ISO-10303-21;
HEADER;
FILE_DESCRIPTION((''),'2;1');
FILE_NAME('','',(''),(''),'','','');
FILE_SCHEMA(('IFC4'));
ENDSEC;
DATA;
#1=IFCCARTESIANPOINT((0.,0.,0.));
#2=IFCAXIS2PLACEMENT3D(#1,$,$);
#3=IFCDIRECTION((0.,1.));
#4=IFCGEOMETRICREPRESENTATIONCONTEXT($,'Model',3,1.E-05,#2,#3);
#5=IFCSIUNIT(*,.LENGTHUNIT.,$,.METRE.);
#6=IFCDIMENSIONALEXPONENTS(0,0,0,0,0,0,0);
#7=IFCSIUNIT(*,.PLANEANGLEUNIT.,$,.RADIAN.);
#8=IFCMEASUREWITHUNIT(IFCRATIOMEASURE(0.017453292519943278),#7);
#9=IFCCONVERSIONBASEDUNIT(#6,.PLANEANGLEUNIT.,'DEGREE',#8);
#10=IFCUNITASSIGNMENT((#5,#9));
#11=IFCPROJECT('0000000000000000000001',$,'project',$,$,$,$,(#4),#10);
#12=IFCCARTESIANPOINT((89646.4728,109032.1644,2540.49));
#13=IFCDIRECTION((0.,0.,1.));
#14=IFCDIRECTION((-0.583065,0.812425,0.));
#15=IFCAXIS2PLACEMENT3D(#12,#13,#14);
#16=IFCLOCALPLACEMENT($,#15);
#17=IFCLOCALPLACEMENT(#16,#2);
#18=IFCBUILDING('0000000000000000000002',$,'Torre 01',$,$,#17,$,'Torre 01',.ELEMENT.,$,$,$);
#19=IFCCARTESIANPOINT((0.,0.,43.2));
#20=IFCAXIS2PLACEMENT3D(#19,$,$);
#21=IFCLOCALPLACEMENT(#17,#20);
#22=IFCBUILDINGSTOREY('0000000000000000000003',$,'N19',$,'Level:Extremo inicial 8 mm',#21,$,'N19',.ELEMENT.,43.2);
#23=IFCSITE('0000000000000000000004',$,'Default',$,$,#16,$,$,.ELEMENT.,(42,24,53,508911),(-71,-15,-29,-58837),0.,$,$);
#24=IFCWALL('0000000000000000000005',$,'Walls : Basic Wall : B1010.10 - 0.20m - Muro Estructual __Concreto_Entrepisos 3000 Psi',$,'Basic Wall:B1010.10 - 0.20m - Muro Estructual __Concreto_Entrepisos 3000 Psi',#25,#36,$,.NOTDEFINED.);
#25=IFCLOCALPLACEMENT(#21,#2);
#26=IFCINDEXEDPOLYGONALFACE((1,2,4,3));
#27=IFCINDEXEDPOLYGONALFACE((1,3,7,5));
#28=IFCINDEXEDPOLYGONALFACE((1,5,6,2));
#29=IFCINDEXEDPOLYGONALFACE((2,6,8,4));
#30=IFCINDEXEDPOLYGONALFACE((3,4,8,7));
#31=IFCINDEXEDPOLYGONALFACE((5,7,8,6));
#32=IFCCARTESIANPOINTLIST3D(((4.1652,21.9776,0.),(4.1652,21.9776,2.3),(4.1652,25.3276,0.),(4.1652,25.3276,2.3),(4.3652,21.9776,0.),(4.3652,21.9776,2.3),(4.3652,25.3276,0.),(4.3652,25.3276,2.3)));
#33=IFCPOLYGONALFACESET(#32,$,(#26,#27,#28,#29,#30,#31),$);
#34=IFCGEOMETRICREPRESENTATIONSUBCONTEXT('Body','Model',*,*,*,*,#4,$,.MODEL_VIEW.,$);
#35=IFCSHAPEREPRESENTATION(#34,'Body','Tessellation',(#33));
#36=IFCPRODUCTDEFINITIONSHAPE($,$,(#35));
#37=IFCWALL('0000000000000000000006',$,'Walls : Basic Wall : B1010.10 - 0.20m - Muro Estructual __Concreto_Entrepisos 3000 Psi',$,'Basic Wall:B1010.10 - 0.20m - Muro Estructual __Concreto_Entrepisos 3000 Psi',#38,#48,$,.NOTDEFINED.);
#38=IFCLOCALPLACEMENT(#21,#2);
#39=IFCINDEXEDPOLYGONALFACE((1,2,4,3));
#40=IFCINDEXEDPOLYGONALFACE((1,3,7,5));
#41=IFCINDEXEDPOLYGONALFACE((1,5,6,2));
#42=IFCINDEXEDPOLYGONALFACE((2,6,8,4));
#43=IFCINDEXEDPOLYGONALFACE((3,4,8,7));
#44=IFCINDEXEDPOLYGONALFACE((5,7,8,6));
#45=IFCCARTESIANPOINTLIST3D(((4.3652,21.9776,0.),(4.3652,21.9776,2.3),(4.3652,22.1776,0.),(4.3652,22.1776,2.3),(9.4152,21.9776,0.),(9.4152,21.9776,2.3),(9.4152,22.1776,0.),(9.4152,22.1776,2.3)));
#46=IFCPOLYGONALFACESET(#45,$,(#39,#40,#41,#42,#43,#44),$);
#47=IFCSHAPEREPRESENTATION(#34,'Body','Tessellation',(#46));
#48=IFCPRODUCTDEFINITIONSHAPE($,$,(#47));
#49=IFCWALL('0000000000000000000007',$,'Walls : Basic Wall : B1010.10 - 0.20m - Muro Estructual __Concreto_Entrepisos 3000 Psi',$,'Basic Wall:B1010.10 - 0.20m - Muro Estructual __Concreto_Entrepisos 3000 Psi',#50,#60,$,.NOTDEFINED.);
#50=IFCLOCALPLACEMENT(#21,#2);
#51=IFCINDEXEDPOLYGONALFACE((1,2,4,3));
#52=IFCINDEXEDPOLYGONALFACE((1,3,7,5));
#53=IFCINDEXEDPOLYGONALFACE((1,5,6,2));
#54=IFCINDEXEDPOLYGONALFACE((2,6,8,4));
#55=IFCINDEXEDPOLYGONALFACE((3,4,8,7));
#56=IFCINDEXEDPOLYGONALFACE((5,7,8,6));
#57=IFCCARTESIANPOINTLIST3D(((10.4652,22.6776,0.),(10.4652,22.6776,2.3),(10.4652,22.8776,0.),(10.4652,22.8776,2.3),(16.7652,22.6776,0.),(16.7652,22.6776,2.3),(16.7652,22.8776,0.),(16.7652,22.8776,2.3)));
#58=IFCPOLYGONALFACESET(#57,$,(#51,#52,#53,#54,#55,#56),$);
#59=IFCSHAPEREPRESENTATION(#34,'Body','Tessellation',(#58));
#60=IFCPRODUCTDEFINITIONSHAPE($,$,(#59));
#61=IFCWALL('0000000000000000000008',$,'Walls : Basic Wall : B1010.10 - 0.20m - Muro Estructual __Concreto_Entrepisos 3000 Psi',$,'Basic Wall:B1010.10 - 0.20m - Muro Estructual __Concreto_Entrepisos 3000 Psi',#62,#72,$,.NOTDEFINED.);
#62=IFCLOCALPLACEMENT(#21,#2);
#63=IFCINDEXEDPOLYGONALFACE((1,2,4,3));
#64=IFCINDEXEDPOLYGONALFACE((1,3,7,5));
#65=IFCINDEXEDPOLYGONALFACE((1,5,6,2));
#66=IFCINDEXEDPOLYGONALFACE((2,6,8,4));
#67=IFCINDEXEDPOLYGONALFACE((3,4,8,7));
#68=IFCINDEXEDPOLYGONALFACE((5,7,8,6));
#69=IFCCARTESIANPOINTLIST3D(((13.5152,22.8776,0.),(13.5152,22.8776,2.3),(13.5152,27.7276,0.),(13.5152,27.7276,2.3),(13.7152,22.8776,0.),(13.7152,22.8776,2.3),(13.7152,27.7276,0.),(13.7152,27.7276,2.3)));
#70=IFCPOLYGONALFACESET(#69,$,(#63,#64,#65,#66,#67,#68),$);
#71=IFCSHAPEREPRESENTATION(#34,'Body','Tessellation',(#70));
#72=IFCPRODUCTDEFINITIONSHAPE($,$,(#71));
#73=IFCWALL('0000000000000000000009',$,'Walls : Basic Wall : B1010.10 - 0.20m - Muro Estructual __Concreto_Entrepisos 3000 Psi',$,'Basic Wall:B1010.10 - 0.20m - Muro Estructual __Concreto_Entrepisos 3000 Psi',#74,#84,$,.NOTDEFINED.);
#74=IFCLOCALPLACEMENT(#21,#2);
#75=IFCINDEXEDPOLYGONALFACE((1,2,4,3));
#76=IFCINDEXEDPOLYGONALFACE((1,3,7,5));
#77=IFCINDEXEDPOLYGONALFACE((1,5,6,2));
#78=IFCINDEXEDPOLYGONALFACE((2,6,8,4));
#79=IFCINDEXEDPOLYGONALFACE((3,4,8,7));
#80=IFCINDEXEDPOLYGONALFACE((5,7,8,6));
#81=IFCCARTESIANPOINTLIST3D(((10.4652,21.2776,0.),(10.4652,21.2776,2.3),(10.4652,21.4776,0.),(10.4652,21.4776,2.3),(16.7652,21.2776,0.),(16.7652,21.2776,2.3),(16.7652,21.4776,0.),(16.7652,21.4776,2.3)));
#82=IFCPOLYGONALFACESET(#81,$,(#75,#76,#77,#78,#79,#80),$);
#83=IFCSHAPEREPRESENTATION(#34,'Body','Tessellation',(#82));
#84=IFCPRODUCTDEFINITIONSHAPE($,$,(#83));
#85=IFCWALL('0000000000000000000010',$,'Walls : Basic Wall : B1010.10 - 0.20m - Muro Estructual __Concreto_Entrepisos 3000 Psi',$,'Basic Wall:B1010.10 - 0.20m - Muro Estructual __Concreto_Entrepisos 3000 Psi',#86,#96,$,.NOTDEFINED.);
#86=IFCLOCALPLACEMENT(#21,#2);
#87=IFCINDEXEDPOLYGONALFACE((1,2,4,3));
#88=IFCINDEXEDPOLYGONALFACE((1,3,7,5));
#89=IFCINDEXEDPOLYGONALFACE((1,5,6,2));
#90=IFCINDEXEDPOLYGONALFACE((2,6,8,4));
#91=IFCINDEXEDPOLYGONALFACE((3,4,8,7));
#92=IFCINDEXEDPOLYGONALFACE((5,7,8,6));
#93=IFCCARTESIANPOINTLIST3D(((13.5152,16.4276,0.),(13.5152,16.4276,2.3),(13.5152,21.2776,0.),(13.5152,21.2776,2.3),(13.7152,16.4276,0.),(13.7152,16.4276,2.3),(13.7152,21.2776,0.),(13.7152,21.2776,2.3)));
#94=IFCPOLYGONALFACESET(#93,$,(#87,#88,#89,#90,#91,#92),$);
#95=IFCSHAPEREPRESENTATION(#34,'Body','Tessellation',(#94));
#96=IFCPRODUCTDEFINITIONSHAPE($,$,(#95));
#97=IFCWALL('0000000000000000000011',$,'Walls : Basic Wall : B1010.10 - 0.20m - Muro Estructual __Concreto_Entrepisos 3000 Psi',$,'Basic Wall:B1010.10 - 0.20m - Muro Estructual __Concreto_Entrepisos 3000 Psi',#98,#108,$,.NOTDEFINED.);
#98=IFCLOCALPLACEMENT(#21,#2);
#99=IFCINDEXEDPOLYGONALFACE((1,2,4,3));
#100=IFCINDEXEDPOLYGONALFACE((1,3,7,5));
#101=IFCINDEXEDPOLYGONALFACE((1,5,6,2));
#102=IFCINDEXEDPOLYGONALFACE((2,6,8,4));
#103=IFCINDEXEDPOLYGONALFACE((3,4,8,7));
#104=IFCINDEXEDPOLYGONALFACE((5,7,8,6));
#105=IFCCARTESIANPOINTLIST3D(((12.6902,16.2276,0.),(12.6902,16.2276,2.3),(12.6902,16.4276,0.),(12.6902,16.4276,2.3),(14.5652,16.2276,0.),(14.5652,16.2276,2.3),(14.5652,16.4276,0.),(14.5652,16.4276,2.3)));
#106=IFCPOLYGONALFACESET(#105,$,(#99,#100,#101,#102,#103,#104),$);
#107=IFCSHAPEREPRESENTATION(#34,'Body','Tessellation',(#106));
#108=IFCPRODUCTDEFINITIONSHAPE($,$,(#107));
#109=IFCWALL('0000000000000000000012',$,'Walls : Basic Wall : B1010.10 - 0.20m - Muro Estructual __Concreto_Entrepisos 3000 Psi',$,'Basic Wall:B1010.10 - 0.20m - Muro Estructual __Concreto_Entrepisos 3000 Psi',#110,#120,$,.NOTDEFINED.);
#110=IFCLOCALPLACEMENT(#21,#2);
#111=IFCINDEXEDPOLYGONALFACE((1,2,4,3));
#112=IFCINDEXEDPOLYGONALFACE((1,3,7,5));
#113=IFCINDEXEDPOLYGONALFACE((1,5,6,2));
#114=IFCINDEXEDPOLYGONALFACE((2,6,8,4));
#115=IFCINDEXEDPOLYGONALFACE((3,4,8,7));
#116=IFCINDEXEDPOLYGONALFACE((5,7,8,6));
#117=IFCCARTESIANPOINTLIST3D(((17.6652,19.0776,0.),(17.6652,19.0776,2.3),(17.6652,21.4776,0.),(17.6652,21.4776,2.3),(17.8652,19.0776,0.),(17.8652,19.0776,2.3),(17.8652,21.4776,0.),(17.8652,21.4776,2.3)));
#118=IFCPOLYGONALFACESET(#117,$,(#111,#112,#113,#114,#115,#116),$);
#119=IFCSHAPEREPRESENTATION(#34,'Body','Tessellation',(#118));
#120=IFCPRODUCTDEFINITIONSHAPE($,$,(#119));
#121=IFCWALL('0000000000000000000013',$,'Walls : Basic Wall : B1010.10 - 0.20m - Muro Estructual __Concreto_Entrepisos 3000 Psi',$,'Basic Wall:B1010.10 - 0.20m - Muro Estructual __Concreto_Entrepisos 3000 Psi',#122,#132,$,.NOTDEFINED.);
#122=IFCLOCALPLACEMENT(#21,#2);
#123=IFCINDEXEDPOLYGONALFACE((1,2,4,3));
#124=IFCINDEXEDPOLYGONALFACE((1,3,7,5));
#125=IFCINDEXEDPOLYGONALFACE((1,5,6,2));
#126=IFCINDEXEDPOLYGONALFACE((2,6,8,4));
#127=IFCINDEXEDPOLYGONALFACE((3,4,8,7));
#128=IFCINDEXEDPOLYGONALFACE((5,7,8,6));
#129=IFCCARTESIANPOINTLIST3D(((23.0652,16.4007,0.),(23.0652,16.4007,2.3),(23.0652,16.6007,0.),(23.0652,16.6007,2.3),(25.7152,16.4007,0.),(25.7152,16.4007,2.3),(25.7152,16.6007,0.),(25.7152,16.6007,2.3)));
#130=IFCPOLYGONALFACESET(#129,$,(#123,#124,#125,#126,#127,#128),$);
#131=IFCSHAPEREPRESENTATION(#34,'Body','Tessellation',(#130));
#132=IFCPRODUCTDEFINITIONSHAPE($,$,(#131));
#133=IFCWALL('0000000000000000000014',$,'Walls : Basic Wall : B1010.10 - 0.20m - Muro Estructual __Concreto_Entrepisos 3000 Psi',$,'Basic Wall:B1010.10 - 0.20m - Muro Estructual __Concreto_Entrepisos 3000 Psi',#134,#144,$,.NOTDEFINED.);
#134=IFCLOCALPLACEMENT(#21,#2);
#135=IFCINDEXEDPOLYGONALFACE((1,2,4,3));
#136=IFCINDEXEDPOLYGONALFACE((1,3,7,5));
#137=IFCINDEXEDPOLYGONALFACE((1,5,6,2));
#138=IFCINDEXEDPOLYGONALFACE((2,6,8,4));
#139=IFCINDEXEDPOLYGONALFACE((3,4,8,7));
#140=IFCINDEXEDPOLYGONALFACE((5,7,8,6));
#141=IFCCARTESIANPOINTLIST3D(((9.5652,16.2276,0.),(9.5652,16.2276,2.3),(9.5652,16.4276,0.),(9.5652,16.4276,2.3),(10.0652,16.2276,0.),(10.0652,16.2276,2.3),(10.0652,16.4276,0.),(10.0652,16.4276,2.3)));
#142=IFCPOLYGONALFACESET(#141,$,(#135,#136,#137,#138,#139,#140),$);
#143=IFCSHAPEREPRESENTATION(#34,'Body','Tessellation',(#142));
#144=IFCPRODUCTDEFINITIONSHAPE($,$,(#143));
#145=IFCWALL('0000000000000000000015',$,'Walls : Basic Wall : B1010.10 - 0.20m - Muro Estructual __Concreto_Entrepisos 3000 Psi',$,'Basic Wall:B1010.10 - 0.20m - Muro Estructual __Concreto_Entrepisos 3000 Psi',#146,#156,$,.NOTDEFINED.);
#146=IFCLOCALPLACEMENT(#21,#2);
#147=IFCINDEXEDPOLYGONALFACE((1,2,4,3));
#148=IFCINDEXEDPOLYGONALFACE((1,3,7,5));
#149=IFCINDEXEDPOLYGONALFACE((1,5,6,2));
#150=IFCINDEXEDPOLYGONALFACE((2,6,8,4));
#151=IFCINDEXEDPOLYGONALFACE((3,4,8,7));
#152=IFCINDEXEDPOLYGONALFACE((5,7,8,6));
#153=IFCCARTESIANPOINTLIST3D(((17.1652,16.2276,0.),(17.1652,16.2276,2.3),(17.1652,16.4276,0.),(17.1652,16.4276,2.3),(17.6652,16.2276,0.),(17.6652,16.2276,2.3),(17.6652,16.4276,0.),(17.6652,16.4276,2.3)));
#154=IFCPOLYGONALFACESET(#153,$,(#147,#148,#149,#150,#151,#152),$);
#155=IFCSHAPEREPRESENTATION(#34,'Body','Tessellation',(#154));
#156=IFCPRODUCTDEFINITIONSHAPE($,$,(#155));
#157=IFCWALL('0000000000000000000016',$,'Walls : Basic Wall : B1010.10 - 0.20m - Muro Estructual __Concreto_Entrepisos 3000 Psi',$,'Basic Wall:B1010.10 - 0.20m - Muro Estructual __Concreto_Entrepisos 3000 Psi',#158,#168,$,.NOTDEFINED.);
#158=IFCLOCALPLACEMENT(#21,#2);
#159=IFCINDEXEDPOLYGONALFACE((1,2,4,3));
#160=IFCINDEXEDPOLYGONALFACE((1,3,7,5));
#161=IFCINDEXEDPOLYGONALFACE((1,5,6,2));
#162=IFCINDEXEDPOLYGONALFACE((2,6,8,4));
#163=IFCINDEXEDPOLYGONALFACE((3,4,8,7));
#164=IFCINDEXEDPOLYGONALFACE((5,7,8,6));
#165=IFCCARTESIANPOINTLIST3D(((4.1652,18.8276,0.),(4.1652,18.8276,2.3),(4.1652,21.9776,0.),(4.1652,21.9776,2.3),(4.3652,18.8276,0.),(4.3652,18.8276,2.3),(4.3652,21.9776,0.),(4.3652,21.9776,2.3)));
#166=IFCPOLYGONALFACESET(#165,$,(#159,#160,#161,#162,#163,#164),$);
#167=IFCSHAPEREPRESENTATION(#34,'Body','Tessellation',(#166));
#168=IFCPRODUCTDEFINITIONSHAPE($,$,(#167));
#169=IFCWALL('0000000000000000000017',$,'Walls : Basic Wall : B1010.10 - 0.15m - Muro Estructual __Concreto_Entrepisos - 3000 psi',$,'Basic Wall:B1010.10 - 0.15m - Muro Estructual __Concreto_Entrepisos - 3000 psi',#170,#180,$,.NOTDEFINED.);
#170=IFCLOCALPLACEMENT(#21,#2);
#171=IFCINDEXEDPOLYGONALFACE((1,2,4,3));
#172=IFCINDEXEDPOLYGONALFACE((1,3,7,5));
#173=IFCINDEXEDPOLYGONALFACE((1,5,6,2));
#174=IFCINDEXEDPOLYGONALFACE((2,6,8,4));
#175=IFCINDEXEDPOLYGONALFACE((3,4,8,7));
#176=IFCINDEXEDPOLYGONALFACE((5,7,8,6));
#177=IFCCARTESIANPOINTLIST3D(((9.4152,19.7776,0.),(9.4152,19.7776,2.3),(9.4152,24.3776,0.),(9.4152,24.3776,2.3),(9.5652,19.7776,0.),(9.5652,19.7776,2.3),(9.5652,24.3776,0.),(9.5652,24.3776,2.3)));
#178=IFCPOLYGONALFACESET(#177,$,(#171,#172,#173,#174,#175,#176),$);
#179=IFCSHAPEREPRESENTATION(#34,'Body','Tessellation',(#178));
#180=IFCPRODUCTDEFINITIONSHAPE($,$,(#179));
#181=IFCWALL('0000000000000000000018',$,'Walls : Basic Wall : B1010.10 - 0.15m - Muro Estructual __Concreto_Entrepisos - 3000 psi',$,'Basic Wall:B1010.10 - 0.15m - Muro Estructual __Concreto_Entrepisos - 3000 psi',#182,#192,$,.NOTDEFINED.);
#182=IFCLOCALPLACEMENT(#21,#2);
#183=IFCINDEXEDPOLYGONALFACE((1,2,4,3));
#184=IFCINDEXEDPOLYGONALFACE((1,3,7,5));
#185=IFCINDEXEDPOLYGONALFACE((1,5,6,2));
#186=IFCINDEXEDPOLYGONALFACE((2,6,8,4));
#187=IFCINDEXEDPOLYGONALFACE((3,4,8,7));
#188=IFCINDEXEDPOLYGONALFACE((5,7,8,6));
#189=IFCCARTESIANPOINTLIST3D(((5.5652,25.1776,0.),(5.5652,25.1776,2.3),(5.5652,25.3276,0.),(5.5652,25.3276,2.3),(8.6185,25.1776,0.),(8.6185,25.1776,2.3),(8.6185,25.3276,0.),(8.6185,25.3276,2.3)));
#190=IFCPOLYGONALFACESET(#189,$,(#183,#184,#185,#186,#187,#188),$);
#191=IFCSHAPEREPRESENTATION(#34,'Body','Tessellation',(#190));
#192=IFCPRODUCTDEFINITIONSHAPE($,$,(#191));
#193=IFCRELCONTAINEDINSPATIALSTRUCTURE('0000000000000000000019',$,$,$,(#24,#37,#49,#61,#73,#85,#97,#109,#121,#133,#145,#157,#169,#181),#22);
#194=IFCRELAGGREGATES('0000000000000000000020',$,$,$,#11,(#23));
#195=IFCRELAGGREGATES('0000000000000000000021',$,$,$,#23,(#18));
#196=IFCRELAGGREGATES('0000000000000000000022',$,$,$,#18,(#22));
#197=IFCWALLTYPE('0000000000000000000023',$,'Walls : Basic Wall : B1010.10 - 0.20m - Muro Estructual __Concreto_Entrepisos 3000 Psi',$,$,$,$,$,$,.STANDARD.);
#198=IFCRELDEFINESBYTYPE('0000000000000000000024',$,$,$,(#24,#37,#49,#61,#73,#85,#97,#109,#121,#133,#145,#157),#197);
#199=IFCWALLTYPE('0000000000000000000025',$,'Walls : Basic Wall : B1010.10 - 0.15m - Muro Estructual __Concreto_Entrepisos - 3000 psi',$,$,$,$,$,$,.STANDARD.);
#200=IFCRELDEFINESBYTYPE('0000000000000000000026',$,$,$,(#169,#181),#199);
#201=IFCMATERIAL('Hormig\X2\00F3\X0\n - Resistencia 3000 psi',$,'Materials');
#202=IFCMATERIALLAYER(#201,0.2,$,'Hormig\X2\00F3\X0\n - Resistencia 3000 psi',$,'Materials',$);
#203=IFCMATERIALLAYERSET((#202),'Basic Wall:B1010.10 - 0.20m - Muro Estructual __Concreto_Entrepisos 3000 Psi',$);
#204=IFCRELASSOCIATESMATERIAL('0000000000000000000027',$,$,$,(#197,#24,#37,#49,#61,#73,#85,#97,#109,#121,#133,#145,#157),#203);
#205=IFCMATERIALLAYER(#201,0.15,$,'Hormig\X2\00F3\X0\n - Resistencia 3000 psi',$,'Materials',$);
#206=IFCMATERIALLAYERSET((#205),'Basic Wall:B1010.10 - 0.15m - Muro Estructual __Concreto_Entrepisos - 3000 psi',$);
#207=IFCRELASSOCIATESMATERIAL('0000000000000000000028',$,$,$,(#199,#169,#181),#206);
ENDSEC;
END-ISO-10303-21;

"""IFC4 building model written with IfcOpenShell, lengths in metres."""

from ifc_helpers import new_model, entity, si_unit, converted_unit, direction, frame, frame_2d, origin, place, context, subcontext, project, spatial, rectangle, extrude, material, layer, layer_set, layer_usage, type_object, element, save


model = new_model("IFC4")

# Units and contexts
model_context = context("Model", 3, precision=1e-05, world=origin(), true_north=direction((0.0, 1.0)))
body_context = subcontext(model_context, "Body", "Model", "MODEL_VIEW")
ifc_project = project(units=[si_unit("LENGTHUNIT", "METRE"), converted_unit("PLANEANGLEUNIT", "DEGREE", entity("IfcRatioMeasure", 0.017453292519943278), si_unit("PLANEANGLEUNIT", "RADIAN"), dimensions=[0, 0, 0, 0, 0, 0, 0])], contexts=[model_context])

# Site, building, storey
site_placement = place(None, frame((89646.4728, 109032.1644, 2540.49), z_axis=(0.0, 0.0, 1.0), x_axis=(-0.583065, 0.812425, 0.0)))
site = spatial("IfcSite", under=ifc_project, at=site_placement, Name="Default", CompositionType="ELEMENT", RefLatitude=(42, 24, 53, 508911), RefLongitude=(-71, -15, -29, -58837), RefElevation=0.0)
building_placement = place(site_placement, origin())
building = spatial("IfcBuilding", under=site, at=building_placement, Name="Torre 01", LongName="Torre 01", CompositionType="ELEMENT")
storey_placement = place(building_placement, frame((0.0, 0.0, 43.2)))
storey = spatial("IfcBuildingStorey", under=building, at=storey_placement, Name="N19", ObjectType="Level:Extremo inicial 8 mm", LongName="N19", CompositionType="ELEMENT", Elevation=43.2)

# Walls
ifc_material = material(Name="Hormigón - Resistencia 3000 psi", Category="Materials")
ifc_layer_1 = layer(ifc_material, 0.2, Name="Hormigón - Resistencia 3000 psi", Category="Materials")
ifc_layer_set_1 = layer_set([ifc_layer_1], Name="Basic Wall:B1010.10 - 0.20m - Muro Estructual __Concreto_Entrepisos 3000 Psi")
ifc_layer_usage_1 = layer_usage(ifc_layer_set_1, "AXIS2", "NEGATIVE", 0.1)
wall_type_1 = type_object("IfcWallType", Name="Walls : Basic Wall : B1010.10 - 0.20m - Muro Estructual __Concreto_Entrepisos 3000 Psi", PredefinedType="STANDARD", material=ifc_layer_set_1)
wall_1_placement = place(storey_placement, frame((4.2652, 25.3276, 0.0), z_axis=(0.0, 0.0, 1.0), x_axis=(0.0, -1.0, 0.0)))
element("IfcWall", 1, at=wall_1_placement, inside=storey, type_object=wall_type_1, material=ifc_layer_usage_1, Name="Walls : Basic Wall : B1010.10 - 0.20m - Muro Estructual __Concreto_Entrepisos 3000 Psi", ObjectType="Basic Wall:B1010.10 - 0.20m - Muro Estructual __Concreto_Entrepisos 3000 Psi", PredefinedType="NOTDEFINED", context=body_context, shape_type="SweptSolid", body=[
    extrude(rectangle(XDim=3.35, YDim=0.2, at=frame_2d((1.675, 0.0), x_axis=(-1.0, 0.0))), origin(), (0.0, 0.0, 1.0), 2.3),
])
ifc_layer_usage_2 = layer_usage(ifc_layer_set_1, "AXIS2", "NEGATIVE", 0.1)
wall_2_placement = place(storey_placement, frame((4.3652, 22.0776, 0.0)))
element("IfcWall", 2, at=wall_2_placement, inside=storey, type_object=wall_type_1, material=ifc_layer_usage_2, Name="Walls : Basic Wall : B1010.10 - 0.20m - Muro Estructual __Concreto_Entrepisos 3000 Psi", ObjectType="Basic Wall:B1010.10 - 0.20m - Muro Estructual __Concreto_Entrepisos 3000 Psi", PredefinedType="NOTDEFINED", context=body_context, shape_type="SweptSolid", body=[
    extrude(rectangle(XDim=5.05, YDim=0.2, at=frame_2d((2.525, 0.0), x_axis=(-1.0, 0.0))), origin(), (0.0, 0.0, 1.0), 2.3),
])
ifc_layer_usage_3 = layer_usage(ifc_layer_set_1, "AXIS2", "NEGATIVE", 0.1)
wall_3_placement = place(storey_placement, frame((10.4652, 22.7776, 0.0)))
element("IfcWall", 3, at=wall_3_placement, inside=storey, type_object=wall_type_1, material=ifc_layer_usage_3, Name="Walls : Basic Wall : B1010.10 - 0.20m - Muro Estructual __Concreto_Entrepisos 3000 Psi", ObjectType="Basic Wall:B1010.10 - 0.20m - Muro Estructual __Concreto_Entrepisos 3000 Psi", PredefinedType="NOTDEFINED", context=body_context, shape_type="SweptSolid", body=[
    extrude(rectangle(XDim=6.3, YDim=0.2, at=frame_2d((3.15, 0.0), x_axis=(-1.0, 0.0))), origin(), (0.0, 0.0, 1.0), 2.3),
])
ifc_layer_usage_4 = layer_usage(ifc_layer_set_1, "AXIS2", "NEGATIVE", 0.1)
wall_4_placement = place(storey_placement, frame((13.6152, 22.8776, 0.0), z_axis=(0.0, 0.0, 1.0), x_axis=(0.0, 1.0, 0.0)))
element("IfcWall", 4, at=wall_4_placement, inside=storey, type_object=wall_type_1, material=ifc_layer_usage_4, Name="Walls : Basic Wall : B1010.10 - 0.20m - Muro Estructual __Concreto_Entrepisos 3000 Psi", ObjectType="Basic Wall:B1010.10 - 0.20m - Muro Estructual __Concreto_Entrepisos 3000 Psi", PredefinedType="NOTDEFINED", context=body_context, shape_type="SweptSolid", body=[
    extrude(rectangle(XDim=4.85, YDim=0.2, at=frame_2d((2.425, 0.0), x_axis=(-1.0, 0.0))), origin(), (0.0, 0.0, 1.0), 2.3),
])
ifc_layer_usage_5 = layer_usage(ifc_layer_set_1, "AXIS2", "NEGATIVE", 0.1)
wall_5_placement = place(storey_placement, frame((10.4652, 21.3776, 0.0)))
element("IfcWall", 5, at=wall_5_placement, inside=storey, type_object=wall_type_1, material=ifc_layer_usage_5, Name="Walls : Basic Wall : B1010.10 - 0.20m - Muro Estructual __Concreto_Entrepisos 3000 Psi", ObjectType="Basic Wall:B1010.10 - 0.20m - Muro Estructual __Concreto_Entrepisos 3000 Psi", PredefinedType="NOTDEFINED", context=body_context, shape_type="SweptSolid", body=[
    extrude(rectangle(XDim=6.3, YDim=0.2, at=frame_2d((3.15, 0.0), x_axis=(-1.0, 0.0))), origin(), (0.0, 0.0, 1.0), 2.3),
])
ifc_layer_usage_6 = layer_usage(ifc_layer_set_1, "AXIS2", "NEGATIVE", 0.1)
wall_6_placement = place(storey_placement, frame((13.6152, 21.2776, 0.0), z_axis=(0.0, 0.0, 1.0), x_axis=(0.0, -1.0, 0.0)))
element("IfcWall", 6, at=wall_6_placement, inside=storey, type_object=wall_type_1, material=ifc_layer_usage_6, Name="Walls : Basic Wall : B1010.10 - 0.20m - Muro Estructual __Concreto_Entrepisos 3000 Psi", ObjectType="Basic Wall:B1010.10 - 0.20m - Muro Estructual __Concreto_Entrepisos 3000 Psi", PredefinedType="NOTDEFINED", context=body_context, shape_type="SweptSolid", body=[
    extrude(rectangle(XDim=4.85, YDim=0.2, at=frame_2d((2.425, 0.0), x_axis=(-1.0, 0.0))), origin(), (0.0, 0.0, 1.0), 2.3),
])
ifc_layer_usage_7 = layer_usage(ifc_layer_set_1, "AXIS2", "NEGATIVE", 0.1)
wall_7_placement = place(storey_placement, frame((12.6902, 16.3276, 0.0)))
element("IfcWall", 7, at=wall_7_placement, inside=storey, type_object=wall_type_1, material=ifc_layer_usage_7, Name="Walls : Basic Wall : B1010.10 - 0.20m - Muro Estructual __Concreto_Entrepisos 3000 Psi", ObjectType="Basic Wall:B1010.10 - 0.20m - Muro Estructual __Concreto_Entrepisos 3000 Psi", PredefinedType="NOTDEFINED", context=body_context, shape_type="SweptSolid", body=[
    extrude(rectangle(XDim=1.875, YDim=0.2, at=frame_2d((0.9375, 0.0), x_axis=(-1.0, 0.0))), origin(), (0.0, 0.0, 1.0), 2.3),
])
ifc_layer_usage_8 = layer_usage(ifc_layer_set_1, "AXIS2", "NEGATIVE", 0.1)
wall_8_placement = place(storey_placement, frame((17.7652, 19.0776, 0.0), z_axis=(0.0, 0.0, 1.0), x_axis=(0.0, 1.0, 0.0)))
element("IfcWall", 8, at=wall_8_placement, inside=storey, type_object=wall_type_1, material=ifc_layer_usage_8, Name="Walls : Basic Wall : B1010.10 - 0.20m - Muro Estructual __Concreto_Entrepisos 3000 Psi", ObjectType="Basic Wall:B1010.10 - 0.20m - Muro Estructual __Concreto_Entrepisos 3000 Psi", PredefinedType="NOTDEFINED", context=body_context, shape_type="SweptSolid", body=[
    extrude(rectangle(XDim=2.4, YDim=0.2, at=frame_2d((1.2, 0.0), x_axis=(-1.0, 0.0))), origin(), (0.0, 0.0, 1.0), 2.3),
])
ifc_layer_usage_9 = layer_usage(ifc_layer_set_1, "AXIS2", "NEGATIVE", 0.1)
wall_9_placement = place(storey_placement, frame((23.0652, 16.5007, 0.0)))
element("IfcWall", 9, at=wall_9_placement, inside=storey, type_object=wall_type_1, material=ifc_layer_usage_9, Name="Walls : Basic Wall : B1010.10 - 0.20m - Muro Estructual __Concreto_Entrepisos 3000 Psi", ObjectType="Basic Wall:B1010.10 - 0.20m - Muro Estructual __Concreto_Entrepisos 3000 Psi", PredefinedType="NOTDEFINED", context=body_context, shape_type="SweptSolid", body=[
    extrude(rectangle(XDim=2.65, YDim=0.2, at=frame_2d((1.325, 0.0), x_axis=(-1.0, 0.0))), origin(), (0.0, 0.0, 1.0), 2.3),
])
ifc_layer_usage_10 = layer_usage(ifc_layer_set_1, "AXIS2", "NEGATIVE", 0.1)
wall_10_placement = place(storey_placement, frame((9.5652, 16.3276, 0.0)))
element("IfcWall", 10, at=wall_10_placement, inside=storey, type_object=wall_type_1, material=ifc_layer_usage_10, Name="Walls : Basic Wall : B1010.10 - 0.20m - Muro Estructual __Concreto_Entrepisos 3000 Psi", ObjectType="Basic Wall:B1010.10 - 0.20m - Muro Estructual __Concreto_Entrepisos 3000 Psi", PredefinedType="NOTDEFINED", context=body_context, shape_type="SweptSolid", body=[
    extrude(rectangle(XDim=0.5, YDim=0.2, at=frame_2d((0.25, 0.0), x_axis=(-1.0, 0.0))), origin(), (0.0, 0.0, 1.0), 2.3),
])
ifc_layer_usage_11 = layer_usage(ifc_layer_set_1, "AXIS2", "NEGATIVE", 0.1)
wall_11_placement = place(storey_placement, frame((17.6652, 16.3276, 0.0), z_axis=(0.0, 0.0, 1.0), x_axis=(-1.0, 0.0, 0.0)))
element("IfcWall", 11, at=wall_11_placement, inside=storey, type_object=wall_type_1, material=ifc_layer_usage_11, Name="Walls : Basic Wall : B1010.10 - 0.20m - Muro Estructual __Concreto_Entrepisos 3000 Psi", ObjectType="Basic Wall:B1010.10 - 0.20m - Muro Estructual __Concreto_Entrepisos 3000 Psi", PredefinedType="NOTDEFINED", context=body_context, shape_type="SweptSolid", body=[
    extrude(rectangle(XDim=0.5, YDim=0.2, at=frame_2d((0.25, 0.0), x_axis=(-1.0, 0.0))), origin(), (0.0, 0.0, 1.0), 2.3),
])
ifc_layer_usage_12 = layer_usage(ifc_layer_set_1, "AXIS2", "NEGATIVE", 0.1)
wall_12_placement = place(storey_placement, frame((4.2652, 21.9776, 0.0), z_axis=(0.0, 0.0, 1.0), x_axis=(0.0, -1.0, 0.0)))
element("IfcWall", 12, at=wall_12_placement, inside=storey, type_object=wall_type_1, material=ifc_layer_usage_12, Name="Walls : Basic Wall : B1010.10 - 0.20m - Muro Estructual __Concreto_Entrepisos 3000 Psi", ObjectType="Basic Wall:B1010.10 - 0.20m - Muro Estructual __Concreto_Entrepisos 3000 Psi", PredefinedType="NOTDEFINED", context=body_context, shape_type="SweptSolid", body=[
    extrude(rectangle(XDim=3.15, YDim=0.2, at=frame_2d((1.575, 0.0), x_axis=(-1.0, 0.0))), origin(), (0.0, 0.0, 1.0), 2.3),
])
ifc_layer_2 = layer(ifc_material, 0.15, Name="Hormigón - Resistencia 3000 psi", Category="Materials")
ifc_layer_set_2 = layer_set([ifc_layer_2], Name="Basic Wall:B1010.10 - 0.15m - Muro Estructual __Concreto_Entrepisos - 3000 psi")
ifc_layer_usage_13 = layer_usage(ifc_layer_set_2, "AXIS2", "NEGATIVE", 0.075)
wall_type_2 = type_object("IfcWallType", Name="Walls : Basic Wall : B1010.10 - 0.15m - Muro Estructual __Concreto_Entrepisos - 3000 psi", PredefinedType="STANDARD", material=ifc_layer_set_2)
wall_13_placement = place(storey_placement, frame((9.4902, 24.3776, 0.0), z_axis=(0.0, 0.0, 1.0), x_axis=(0.0, -1.0, 0.0)))
element("IfcWall", 13, at=wall_13_placement, inside=storey, type_object=wall_type_2, material=ifc_layer_usage_13, Name="Walls : Basic Wall : B1010.10 - 0.15m - Muro Estructual __Concreto_Entrepisos - 3000 psi", ObjectType="Basic Wall:B1010.10 - 0.15m - Muro Estructual __Concreto_Entrepisos - 3000 psi", PredefinedType="NOTDEFINED", context=body_context, shape_type="SweptSolid", body=[
    extrude(rectangle(XDim=4.6, YDim=0.15, at=frame_2d((2.3, 0.0), x_axis=(-1.0, 0.0))), origin(), (0.0, 0.0, 1.0), 2.3),
])
ifc_layer_usage_14 = layer_usage(ifc_layer_set_2, "AXIS2", "NEGATIVE", 0.075)
wall_14_placement = place(storey_placement, frame((5.5652, 25.2526, 0.0)))
element("IfcWall", 14, at=wall_14_placement, inside=storey, type_object=wall_type_2, material=ifc_layer_usage_14, Name="Walls : Basic Wall : B1010.10 - 0.15m - Muro Estructual __Concreto_Entrepisos - 3000 psi", ObjectType="Basic Wall:B1010.10 - 0.15m - Muro Estructual __Concreto_Entrepisos - 3000 psi", PredefinedType="NOTDEFINED", context=body_context, shape_type="SweptSolid", body=[
    extrude(rectangle(XDim=3.0533, YDim=0.15, at=frame_2d((1.5267, 0.0), x_axis=(-1.0, 0.0))), origin(), (0.0, 0.0, 1.0), 2.3),
])

save(model, "model.ifc")
